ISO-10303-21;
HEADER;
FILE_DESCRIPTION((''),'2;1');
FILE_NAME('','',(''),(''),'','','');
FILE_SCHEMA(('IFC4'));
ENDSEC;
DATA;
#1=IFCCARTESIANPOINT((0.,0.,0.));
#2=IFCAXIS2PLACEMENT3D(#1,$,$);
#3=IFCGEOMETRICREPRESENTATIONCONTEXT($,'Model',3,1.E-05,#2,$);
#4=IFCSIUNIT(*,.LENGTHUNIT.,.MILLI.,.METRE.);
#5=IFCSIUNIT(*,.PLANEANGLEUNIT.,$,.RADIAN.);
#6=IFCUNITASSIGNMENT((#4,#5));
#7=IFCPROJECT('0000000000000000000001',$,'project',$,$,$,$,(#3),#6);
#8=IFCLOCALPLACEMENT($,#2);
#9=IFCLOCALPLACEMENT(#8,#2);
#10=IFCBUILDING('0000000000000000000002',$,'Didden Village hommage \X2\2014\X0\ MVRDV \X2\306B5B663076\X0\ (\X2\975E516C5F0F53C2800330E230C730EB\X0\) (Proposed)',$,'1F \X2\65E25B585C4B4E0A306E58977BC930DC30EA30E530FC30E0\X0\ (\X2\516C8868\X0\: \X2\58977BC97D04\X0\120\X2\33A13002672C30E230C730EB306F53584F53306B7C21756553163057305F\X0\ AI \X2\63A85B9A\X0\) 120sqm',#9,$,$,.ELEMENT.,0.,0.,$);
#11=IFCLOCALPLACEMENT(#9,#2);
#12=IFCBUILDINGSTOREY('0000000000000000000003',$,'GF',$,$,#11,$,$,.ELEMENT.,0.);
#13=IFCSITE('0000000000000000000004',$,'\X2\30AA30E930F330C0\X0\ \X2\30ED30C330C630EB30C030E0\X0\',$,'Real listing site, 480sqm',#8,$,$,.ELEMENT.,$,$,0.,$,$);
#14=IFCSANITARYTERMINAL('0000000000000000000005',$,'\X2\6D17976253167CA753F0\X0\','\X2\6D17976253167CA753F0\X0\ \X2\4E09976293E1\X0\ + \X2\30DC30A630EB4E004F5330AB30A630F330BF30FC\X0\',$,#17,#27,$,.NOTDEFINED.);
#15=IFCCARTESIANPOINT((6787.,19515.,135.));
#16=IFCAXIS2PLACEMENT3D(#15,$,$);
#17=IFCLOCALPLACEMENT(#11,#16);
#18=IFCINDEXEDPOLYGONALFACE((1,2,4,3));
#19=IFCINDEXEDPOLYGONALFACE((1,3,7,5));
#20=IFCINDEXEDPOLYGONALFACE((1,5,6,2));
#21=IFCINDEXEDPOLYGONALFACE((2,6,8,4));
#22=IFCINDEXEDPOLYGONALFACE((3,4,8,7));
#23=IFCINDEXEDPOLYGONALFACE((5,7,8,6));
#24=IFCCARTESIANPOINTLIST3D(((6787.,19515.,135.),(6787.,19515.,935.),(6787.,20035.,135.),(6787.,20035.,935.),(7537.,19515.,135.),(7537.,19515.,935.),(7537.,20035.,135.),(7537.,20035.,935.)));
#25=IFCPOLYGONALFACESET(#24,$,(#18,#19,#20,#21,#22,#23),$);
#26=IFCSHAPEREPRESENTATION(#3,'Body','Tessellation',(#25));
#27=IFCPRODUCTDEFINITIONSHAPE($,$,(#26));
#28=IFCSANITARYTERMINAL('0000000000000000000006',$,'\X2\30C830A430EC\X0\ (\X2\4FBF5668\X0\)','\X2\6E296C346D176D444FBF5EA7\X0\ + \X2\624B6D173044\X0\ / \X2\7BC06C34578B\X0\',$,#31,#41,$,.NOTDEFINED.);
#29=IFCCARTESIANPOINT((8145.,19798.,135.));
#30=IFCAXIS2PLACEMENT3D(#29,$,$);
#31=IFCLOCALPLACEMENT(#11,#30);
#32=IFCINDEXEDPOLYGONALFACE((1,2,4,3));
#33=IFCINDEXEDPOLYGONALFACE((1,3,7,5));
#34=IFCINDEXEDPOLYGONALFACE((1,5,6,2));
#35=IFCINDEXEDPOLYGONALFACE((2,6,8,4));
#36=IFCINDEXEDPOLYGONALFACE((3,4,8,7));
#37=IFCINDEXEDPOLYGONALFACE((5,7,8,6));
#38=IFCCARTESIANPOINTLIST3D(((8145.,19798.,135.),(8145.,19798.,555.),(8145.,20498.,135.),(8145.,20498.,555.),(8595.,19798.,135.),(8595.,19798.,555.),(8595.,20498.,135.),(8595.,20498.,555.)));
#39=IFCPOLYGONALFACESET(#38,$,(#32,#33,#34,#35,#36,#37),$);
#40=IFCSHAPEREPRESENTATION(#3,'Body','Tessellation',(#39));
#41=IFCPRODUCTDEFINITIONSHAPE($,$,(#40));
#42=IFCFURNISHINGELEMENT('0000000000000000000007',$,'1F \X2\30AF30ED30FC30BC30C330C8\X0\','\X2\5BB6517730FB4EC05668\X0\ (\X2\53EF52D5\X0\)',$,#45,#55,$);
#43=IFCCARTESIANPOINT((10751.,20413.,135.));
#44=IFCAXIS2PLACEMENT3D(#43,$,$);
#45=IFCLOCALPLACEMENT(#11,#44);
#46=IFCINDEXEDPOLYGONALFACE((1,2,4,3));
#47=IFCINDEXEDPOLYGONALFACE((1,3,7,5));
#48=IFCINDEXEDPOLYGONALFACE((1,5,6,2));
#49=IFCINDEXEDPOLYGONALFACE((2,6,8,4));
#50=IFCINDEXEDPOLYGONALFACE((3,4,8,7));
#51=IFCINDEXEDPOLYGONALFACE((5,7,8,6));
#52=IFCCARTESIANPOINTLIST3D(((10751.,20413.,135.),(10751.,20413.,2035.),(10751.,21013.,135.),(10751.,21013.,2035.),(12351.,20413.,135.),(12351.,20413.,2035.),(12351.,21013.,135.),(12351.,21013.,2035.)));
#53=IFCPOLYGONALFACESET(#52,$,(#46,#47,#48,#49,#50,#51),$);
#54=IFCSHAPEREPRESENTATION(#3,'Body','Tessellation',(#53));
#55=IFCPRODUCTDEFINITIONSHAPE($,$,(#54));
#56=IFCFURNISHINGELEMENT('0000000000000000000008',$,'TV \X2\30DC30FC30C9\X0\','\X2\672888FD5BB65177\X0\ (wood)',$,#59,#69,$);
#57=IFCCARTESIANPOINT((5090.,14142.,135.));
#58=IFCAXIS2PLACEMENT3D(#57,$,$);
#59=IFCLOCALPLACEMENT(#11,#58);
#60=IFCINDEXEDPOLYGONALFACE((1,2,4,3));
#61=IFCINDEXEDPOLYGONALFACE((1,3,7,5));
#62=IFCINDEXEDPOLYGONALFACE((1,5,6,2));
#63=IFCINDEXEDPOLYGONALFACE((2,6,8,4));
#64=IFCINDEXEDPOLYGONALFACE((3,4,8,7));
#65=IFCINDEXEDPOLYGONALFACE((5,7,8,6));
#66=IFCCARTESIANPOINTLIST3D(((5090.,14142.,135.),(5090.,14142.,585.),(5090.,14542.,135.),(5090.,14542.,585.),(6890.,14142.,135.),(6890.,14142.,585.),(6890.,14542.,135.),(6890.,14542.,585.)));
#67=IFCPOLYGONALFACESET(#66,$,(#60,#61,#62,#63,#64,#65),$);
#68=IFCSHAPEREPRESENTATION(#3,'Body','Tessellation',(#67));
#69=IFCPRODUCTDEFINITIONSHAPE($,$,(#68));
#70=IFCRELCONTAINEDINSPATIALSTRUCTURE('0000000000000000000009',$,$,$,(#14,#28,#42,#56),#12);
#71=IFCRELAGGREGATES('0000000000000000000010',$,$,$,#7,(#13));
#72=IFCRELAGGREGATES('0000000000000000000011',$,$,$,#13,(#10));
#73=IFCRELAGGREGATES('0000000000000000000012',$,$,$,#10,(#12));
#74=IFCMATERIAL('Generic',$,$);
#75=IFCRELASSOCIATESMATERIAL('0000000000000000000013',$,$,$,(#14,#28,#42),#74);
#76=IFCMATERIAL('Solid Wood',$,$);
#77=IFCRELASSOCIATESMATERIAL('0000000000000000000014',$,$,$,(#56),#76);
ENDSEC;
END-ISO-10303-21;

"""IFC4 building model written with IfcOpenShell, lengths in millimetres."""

from ifc_helpers import new_model, si_unit, frame, frame_2d, origin, place, context, project, spatial, rectangle, extrude, material, element, save


model = new_model("IFC4")

# Units and contexts
model_context = context("Model", 3, precision=1e-05, world=origin())
ifc_project = project(units=[si_unit("LENGTHUNIT", "METRE", prefix="MILLI"), si_unit("PLANEANGLEUNIT", "RADIAN")], contexts=[model_context])

# Site, building, storey
site_placement = place(None, origin())
site = spatial("IfcSite", under=ifc_project, at=site_placement, Name="オランダ ロッテルダム", ObjectType="Real listing site, 480sqm", CompositionType="ELEMENT", RefElevation=0.0)
building_placement = place(site_placement, origin())
building = spatial("IfcBuilding", under=site, at=building_placement, Name="Didden Village hommage — MVRDV に学ぶ (非公式参考モデル) (Proposed)", ObjectType="1F 既存屋上の増築ボリューム (公表: 増築約120㎡。本モデルは単体に簡略化した AI 推定) 120sqm", CompositionType="ELEMENT", ElevationOfRefHeight=0.0, ElevationOfTerrain=0.0)
storey_placement = place(building_placement, origin())
storey = spatial("IfcBuildingStorey", under=building, at=storey_placement, Name="GF", CompositionType="ELEMENT", Elevation=0.0)

# Shared definitions
ifc_material_1 = material(Name="Solid Wood")

# Sanitary terminals
ifc_material_2 = material(Name="Generic")
sanitary_terminal_1_placement = place(storey_placement, frame((6787.0, 19515.0, 135.0)))
element("IfcSanitaryTerminal", 1, at=sanitary_terminal_1_placement, inside=storey, material=ifc_material_2, Name="洗面化粧台", Description="洗面化粧台 三面鏡 + ボウル一体カウンター", PredefinedType="NOTDEFINED", context=model_context, shape_type="SweptSolid", body=[
    extrude(rectangle(XDim=750.0, YDim=520.0, at=frame_2d((375.0, 260.0))), frame((6787.0, 19515.0, 135.0)), (0.0, 0.0, 1.0), 800.0),
])
sanitary_terminal_2_placement = place(storey_placement, frame((8145.0, 19798.0, 135.0)))
element("IfcSanitaryTerminal", 2, at=sanitary_terminal_2_placement, inside=storey, material=ifc_material_2, Name="トイレ (便器)", Description="温水洗浄便座 + 手洗い / 節水型", PredefinedType="NOTDEFINED", context=model_context, shape_type="SweptSolid", body=[
    extrude(rectangle(XDim=450.0, YDim=700.0, at=frame_2d((225.0, 350.0))), frame((8145.0, 19798.0, 135.0)), (0.0, 0.0, 1.0), 420.0),
])

# Furnishing elements
furnishing_1_placement = place(storey_placement, frame((10751.0, 20413.0, 135.0)))
element("IfcFurnishingElement", 3, at=furnishing_1_placement, inside=storey, material=ifc_material_2, Name="1F クローゼット", Description="家具・什器 (可動)", context=model_context, shape_type="SweptSolid", body=[
    extrude(rectangle(XDim=1600.0, YDim=600.0, at=frame_2d((800.0, 300.0))), frame((10751.0, 20413.0, 135.0)), (0.0, 0.0, 1.0), 1900.0),
])
furnishing_2_placement = place(storey_placement, frame((5090.0, 14142.0, 135.0)))
element("IfcFurnishingElement", 4, at=furnishing_2_placement, inside=storey, material=ifc_material_1, Name="TV ボード", Description="木製家具 (wood)", context=model_context, shape_type="SweptSolid", body=[
    extrude(rectangle(XDim=1800.0, YDim=400.0, at=frame_2d((900.0, 200.0))), frame((5090.0, 14142.0, 135.0)), (0.0, 0.0, 1.0), 450.0),
])

save(model, "model.ifc")
